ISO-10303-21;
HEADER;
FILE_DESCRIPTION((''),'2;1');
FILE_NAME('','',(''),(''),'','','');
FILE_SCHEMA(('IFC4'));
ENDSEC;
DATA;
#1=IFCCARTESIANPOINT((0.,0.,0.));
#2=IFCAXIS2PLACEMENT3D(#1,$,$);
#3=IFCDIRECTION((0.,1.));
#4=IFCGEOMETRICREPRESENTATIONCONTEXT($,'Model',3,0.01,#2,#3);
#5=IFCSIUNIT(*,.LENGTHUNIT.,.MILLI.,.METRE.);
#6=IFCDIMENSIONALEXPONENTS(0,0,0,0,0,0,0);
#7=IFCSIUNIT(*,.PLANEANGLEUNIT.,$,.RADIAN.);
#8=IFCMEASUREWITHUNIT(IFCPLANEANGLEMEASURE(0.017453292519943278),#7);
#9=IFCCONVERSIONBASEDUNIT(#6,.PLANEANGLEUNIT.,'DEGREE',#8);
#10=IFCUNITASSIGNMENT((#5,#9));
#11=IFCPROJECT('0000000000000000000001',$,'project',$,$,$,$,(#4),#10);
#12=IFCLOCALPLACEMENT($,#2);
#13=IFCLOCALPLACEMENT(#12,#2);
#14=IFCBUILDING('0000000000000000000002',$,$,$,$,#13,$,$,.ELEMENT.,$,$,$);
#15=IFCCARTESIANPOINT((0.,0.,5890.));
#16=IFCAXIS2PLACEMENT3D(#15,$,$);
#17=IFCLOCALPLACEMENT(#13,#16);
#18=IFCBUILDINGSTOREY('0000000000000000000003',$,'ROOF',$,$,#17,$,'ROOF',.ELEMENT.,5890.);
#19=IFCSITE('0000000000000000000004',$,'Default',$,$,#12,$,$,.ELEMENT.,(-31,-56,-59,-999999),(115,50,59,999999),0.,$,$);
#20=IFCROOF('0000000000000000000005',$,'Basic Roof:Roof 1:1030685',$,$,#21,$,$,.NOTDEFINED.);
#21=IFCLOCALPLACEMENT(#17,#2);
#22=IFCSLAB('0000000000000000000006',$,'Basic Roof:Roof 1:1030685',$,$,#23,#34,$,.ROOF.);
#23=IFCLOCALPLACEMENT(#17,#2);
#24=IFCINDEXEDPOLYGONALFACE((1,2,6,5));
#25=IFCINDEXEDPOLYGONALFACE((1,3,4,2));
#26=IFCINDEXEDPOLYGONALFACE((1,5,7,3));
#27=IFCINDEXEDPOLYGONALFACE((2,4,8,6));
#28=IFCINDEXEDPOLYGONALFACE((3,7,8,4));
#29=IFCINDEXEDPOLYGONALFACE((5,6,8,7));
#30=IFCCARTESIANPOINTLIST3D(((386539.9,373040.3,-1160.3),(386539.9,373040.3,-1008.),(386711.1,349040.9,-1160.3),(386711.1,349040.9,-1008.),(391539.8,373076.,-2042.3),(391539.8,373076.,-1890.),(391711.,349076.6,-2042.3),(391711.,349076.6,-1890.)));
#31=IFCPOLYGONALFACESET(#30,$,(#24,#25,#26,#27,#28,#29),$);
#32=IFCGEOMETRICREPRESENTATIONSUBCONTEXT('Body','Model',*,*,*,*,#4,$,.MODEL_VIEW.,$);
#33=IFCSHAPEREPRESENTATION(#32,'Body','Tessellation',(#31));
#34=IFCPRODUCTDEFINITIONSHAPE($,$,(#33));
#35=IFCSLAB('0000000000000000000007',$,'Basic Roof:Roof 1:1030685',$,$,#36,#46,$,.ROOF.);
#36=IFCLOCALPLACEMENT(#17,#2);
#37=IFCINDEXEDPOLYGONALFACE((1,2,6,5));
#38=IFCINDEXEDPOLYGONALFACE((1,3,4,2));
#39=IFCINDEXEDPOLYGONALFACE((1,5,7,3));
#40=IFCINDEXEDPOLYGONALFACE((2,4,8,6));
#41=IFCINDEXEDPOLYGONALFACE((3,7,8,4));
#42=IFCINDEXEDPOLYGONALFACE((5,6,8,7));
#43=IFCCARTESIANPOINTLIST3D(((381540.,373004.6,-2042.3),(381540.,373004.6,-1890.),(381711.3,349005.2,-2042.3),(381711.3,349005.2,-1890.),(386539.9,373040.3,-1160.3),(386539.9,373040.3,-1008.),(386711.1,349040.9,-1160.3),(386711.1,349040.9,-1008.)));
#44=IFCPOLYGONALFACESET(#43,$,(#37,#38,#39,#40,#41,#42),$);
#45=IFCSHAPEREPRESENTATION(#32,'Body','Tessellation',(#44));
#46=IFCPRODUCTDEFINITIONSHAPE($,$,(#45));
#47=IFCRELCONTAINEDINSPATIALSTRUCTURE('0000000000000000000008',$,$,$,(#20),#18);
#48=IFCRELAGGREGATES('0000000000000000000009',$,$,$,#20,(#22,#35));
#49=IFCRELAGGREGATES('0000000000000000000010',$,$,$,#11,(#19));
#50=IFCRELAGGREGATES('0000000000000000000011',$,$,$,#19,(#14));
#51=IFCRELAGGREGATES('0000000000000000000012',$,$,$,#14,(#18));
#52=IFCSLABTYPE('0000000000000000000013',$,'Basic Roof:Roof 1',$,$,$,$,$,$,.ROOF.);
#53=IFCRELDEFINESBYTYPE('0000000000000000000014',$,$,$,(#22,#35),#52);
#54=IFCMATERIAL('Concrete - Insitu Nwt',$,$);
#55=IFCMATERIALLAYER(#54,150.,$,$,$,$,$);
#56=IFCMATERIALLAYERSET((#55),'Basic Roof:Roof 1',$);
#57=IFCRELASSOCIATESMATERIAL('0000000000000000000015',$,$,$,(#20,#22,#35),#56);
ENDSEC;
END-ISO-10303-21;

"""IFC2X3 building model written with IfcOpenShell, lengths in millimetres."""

from ifc_helpers import new_model, entity, si_unit, converted_unit, direction, frame, frame_2d, origin, place, context, subcontext, project, spatial, rectangle, extrude, material, layer, layer_set, type_object, element, aggregate, save


model = new_model("IFC2X3")

# Units and contexts
model_context = context("Model", 3, precision=0.01, world=origin(), true_north=direction((0.0, 1.0)))
body_context = subcontext(model_context, "Body", "Model", "MODEL_VIEW")
ifc_project = project(units=[si_unit("LENGTHUNIT", "METRE", prefix="MILLI"), converted_unit("PLANEANGLEUNIT", "DEGREE", entity("IfcPlaneAngleMeasure", 0.017453292519943278), si_unit("PLANEANGLEUNIT", "RADIAN"), dimensions=[0, 0, 0, 0, 0, 0, 0])], contexts=[model_context])

# Site, building, storey
site_placement = place(None, origin())
site = spatial("IfcSite", under=ifc_project, at=site_placement, Name="Default", CompositionType="ELEMENT", RefLatitude=(-31, -56, -59, -999999), RefLongitude=(115, 50, 59, 999999), RefElevation=0.0)
building_placement = place(site_placement, origin())
building = spatial("IfcBuilding", under=site, at=building_placement, CompositionType="ELEMENT")
storey_placement = place(building_placement, frame((0.0, 0.0, 5890.0)))
storey = spatial("IfcBuildingStorey", under=building, at=storey_placement, Name="ROOF", LongName="ROOF", CompositionType="ELEMENT", Elevation=5890.0)

# Roof, slabs
ifc_material = material(Name="Concrete - Insitu Nwt")
ifc_layer = layer(ifc_material, 150.0)
ifc_layer_set = layer_set([ifc_layer], Name="Basic Roof:Roof 1")
roof_placement = place(storey_placement, frame((381540.0, 349005.2, -2042.3)))
roof = element("IfcRoof", 1, at=roof_placement, inside=storey, material=ifc_layer_set, Name="Basic Roof:Roof 1:1030685", ShapeType="NOTDEFINED")
slab_type = type_object("IfcSlabType", Name="Basic Roof:Roof 1", PredefinedType="ROOF")
slab_1_placement = place(roof_placement, origin())
slab_1 = element("IfcSlab", 2, at=slab_1_placement, type_object=slab_type, material=ifc_layer_set, Name="Basic Roof:Roof 1:1030685", PredefinedType="ROOF", context=body_context, shape_type="SweptSolid", body=[
    extrude(rectangle(XDim=5077.2, YDim=24000.0, at=frame_2d((0.0, 0.0), x_axis=(-0.999974, -0.007244))), frame((7585.4, 12053.2, 441.0), z_axis=(0.173713, 0.001239, 0.984795), x_axis=(0.984796, -0.000219, -0.173713)), (-0.173713, -0.001258, 0.984795), 152.3),
])
slab_2_placement = place(roof_placement, origin())
slab_2 = element("IfcSlab", 3, at=slab_2_placement, type_object=slab_type, material=ifc_layer_set, Name="Basic Roof:Roof 1:1030685", PredefinedType="ROOF", context=body_context, shape_type="SweptSolid", body=[
    extrude(rectangle(XDim=5077.2, YDim=24000.0, at=frame_2d((0.0, 0.0), x_axis=(-0.999974, -0.007244))), frame((2585.5, 12017.5, 441.0), z_axis=(-0.173713, -0.001239, 0.984795), x_axis=(0.984796, -0.000219, 0.173713)), (0.173713, 0.001258, 0.984795), 152.3),
])
aggregate(roof, [slab_1, slab_2])

save(model, "model.ifc")
